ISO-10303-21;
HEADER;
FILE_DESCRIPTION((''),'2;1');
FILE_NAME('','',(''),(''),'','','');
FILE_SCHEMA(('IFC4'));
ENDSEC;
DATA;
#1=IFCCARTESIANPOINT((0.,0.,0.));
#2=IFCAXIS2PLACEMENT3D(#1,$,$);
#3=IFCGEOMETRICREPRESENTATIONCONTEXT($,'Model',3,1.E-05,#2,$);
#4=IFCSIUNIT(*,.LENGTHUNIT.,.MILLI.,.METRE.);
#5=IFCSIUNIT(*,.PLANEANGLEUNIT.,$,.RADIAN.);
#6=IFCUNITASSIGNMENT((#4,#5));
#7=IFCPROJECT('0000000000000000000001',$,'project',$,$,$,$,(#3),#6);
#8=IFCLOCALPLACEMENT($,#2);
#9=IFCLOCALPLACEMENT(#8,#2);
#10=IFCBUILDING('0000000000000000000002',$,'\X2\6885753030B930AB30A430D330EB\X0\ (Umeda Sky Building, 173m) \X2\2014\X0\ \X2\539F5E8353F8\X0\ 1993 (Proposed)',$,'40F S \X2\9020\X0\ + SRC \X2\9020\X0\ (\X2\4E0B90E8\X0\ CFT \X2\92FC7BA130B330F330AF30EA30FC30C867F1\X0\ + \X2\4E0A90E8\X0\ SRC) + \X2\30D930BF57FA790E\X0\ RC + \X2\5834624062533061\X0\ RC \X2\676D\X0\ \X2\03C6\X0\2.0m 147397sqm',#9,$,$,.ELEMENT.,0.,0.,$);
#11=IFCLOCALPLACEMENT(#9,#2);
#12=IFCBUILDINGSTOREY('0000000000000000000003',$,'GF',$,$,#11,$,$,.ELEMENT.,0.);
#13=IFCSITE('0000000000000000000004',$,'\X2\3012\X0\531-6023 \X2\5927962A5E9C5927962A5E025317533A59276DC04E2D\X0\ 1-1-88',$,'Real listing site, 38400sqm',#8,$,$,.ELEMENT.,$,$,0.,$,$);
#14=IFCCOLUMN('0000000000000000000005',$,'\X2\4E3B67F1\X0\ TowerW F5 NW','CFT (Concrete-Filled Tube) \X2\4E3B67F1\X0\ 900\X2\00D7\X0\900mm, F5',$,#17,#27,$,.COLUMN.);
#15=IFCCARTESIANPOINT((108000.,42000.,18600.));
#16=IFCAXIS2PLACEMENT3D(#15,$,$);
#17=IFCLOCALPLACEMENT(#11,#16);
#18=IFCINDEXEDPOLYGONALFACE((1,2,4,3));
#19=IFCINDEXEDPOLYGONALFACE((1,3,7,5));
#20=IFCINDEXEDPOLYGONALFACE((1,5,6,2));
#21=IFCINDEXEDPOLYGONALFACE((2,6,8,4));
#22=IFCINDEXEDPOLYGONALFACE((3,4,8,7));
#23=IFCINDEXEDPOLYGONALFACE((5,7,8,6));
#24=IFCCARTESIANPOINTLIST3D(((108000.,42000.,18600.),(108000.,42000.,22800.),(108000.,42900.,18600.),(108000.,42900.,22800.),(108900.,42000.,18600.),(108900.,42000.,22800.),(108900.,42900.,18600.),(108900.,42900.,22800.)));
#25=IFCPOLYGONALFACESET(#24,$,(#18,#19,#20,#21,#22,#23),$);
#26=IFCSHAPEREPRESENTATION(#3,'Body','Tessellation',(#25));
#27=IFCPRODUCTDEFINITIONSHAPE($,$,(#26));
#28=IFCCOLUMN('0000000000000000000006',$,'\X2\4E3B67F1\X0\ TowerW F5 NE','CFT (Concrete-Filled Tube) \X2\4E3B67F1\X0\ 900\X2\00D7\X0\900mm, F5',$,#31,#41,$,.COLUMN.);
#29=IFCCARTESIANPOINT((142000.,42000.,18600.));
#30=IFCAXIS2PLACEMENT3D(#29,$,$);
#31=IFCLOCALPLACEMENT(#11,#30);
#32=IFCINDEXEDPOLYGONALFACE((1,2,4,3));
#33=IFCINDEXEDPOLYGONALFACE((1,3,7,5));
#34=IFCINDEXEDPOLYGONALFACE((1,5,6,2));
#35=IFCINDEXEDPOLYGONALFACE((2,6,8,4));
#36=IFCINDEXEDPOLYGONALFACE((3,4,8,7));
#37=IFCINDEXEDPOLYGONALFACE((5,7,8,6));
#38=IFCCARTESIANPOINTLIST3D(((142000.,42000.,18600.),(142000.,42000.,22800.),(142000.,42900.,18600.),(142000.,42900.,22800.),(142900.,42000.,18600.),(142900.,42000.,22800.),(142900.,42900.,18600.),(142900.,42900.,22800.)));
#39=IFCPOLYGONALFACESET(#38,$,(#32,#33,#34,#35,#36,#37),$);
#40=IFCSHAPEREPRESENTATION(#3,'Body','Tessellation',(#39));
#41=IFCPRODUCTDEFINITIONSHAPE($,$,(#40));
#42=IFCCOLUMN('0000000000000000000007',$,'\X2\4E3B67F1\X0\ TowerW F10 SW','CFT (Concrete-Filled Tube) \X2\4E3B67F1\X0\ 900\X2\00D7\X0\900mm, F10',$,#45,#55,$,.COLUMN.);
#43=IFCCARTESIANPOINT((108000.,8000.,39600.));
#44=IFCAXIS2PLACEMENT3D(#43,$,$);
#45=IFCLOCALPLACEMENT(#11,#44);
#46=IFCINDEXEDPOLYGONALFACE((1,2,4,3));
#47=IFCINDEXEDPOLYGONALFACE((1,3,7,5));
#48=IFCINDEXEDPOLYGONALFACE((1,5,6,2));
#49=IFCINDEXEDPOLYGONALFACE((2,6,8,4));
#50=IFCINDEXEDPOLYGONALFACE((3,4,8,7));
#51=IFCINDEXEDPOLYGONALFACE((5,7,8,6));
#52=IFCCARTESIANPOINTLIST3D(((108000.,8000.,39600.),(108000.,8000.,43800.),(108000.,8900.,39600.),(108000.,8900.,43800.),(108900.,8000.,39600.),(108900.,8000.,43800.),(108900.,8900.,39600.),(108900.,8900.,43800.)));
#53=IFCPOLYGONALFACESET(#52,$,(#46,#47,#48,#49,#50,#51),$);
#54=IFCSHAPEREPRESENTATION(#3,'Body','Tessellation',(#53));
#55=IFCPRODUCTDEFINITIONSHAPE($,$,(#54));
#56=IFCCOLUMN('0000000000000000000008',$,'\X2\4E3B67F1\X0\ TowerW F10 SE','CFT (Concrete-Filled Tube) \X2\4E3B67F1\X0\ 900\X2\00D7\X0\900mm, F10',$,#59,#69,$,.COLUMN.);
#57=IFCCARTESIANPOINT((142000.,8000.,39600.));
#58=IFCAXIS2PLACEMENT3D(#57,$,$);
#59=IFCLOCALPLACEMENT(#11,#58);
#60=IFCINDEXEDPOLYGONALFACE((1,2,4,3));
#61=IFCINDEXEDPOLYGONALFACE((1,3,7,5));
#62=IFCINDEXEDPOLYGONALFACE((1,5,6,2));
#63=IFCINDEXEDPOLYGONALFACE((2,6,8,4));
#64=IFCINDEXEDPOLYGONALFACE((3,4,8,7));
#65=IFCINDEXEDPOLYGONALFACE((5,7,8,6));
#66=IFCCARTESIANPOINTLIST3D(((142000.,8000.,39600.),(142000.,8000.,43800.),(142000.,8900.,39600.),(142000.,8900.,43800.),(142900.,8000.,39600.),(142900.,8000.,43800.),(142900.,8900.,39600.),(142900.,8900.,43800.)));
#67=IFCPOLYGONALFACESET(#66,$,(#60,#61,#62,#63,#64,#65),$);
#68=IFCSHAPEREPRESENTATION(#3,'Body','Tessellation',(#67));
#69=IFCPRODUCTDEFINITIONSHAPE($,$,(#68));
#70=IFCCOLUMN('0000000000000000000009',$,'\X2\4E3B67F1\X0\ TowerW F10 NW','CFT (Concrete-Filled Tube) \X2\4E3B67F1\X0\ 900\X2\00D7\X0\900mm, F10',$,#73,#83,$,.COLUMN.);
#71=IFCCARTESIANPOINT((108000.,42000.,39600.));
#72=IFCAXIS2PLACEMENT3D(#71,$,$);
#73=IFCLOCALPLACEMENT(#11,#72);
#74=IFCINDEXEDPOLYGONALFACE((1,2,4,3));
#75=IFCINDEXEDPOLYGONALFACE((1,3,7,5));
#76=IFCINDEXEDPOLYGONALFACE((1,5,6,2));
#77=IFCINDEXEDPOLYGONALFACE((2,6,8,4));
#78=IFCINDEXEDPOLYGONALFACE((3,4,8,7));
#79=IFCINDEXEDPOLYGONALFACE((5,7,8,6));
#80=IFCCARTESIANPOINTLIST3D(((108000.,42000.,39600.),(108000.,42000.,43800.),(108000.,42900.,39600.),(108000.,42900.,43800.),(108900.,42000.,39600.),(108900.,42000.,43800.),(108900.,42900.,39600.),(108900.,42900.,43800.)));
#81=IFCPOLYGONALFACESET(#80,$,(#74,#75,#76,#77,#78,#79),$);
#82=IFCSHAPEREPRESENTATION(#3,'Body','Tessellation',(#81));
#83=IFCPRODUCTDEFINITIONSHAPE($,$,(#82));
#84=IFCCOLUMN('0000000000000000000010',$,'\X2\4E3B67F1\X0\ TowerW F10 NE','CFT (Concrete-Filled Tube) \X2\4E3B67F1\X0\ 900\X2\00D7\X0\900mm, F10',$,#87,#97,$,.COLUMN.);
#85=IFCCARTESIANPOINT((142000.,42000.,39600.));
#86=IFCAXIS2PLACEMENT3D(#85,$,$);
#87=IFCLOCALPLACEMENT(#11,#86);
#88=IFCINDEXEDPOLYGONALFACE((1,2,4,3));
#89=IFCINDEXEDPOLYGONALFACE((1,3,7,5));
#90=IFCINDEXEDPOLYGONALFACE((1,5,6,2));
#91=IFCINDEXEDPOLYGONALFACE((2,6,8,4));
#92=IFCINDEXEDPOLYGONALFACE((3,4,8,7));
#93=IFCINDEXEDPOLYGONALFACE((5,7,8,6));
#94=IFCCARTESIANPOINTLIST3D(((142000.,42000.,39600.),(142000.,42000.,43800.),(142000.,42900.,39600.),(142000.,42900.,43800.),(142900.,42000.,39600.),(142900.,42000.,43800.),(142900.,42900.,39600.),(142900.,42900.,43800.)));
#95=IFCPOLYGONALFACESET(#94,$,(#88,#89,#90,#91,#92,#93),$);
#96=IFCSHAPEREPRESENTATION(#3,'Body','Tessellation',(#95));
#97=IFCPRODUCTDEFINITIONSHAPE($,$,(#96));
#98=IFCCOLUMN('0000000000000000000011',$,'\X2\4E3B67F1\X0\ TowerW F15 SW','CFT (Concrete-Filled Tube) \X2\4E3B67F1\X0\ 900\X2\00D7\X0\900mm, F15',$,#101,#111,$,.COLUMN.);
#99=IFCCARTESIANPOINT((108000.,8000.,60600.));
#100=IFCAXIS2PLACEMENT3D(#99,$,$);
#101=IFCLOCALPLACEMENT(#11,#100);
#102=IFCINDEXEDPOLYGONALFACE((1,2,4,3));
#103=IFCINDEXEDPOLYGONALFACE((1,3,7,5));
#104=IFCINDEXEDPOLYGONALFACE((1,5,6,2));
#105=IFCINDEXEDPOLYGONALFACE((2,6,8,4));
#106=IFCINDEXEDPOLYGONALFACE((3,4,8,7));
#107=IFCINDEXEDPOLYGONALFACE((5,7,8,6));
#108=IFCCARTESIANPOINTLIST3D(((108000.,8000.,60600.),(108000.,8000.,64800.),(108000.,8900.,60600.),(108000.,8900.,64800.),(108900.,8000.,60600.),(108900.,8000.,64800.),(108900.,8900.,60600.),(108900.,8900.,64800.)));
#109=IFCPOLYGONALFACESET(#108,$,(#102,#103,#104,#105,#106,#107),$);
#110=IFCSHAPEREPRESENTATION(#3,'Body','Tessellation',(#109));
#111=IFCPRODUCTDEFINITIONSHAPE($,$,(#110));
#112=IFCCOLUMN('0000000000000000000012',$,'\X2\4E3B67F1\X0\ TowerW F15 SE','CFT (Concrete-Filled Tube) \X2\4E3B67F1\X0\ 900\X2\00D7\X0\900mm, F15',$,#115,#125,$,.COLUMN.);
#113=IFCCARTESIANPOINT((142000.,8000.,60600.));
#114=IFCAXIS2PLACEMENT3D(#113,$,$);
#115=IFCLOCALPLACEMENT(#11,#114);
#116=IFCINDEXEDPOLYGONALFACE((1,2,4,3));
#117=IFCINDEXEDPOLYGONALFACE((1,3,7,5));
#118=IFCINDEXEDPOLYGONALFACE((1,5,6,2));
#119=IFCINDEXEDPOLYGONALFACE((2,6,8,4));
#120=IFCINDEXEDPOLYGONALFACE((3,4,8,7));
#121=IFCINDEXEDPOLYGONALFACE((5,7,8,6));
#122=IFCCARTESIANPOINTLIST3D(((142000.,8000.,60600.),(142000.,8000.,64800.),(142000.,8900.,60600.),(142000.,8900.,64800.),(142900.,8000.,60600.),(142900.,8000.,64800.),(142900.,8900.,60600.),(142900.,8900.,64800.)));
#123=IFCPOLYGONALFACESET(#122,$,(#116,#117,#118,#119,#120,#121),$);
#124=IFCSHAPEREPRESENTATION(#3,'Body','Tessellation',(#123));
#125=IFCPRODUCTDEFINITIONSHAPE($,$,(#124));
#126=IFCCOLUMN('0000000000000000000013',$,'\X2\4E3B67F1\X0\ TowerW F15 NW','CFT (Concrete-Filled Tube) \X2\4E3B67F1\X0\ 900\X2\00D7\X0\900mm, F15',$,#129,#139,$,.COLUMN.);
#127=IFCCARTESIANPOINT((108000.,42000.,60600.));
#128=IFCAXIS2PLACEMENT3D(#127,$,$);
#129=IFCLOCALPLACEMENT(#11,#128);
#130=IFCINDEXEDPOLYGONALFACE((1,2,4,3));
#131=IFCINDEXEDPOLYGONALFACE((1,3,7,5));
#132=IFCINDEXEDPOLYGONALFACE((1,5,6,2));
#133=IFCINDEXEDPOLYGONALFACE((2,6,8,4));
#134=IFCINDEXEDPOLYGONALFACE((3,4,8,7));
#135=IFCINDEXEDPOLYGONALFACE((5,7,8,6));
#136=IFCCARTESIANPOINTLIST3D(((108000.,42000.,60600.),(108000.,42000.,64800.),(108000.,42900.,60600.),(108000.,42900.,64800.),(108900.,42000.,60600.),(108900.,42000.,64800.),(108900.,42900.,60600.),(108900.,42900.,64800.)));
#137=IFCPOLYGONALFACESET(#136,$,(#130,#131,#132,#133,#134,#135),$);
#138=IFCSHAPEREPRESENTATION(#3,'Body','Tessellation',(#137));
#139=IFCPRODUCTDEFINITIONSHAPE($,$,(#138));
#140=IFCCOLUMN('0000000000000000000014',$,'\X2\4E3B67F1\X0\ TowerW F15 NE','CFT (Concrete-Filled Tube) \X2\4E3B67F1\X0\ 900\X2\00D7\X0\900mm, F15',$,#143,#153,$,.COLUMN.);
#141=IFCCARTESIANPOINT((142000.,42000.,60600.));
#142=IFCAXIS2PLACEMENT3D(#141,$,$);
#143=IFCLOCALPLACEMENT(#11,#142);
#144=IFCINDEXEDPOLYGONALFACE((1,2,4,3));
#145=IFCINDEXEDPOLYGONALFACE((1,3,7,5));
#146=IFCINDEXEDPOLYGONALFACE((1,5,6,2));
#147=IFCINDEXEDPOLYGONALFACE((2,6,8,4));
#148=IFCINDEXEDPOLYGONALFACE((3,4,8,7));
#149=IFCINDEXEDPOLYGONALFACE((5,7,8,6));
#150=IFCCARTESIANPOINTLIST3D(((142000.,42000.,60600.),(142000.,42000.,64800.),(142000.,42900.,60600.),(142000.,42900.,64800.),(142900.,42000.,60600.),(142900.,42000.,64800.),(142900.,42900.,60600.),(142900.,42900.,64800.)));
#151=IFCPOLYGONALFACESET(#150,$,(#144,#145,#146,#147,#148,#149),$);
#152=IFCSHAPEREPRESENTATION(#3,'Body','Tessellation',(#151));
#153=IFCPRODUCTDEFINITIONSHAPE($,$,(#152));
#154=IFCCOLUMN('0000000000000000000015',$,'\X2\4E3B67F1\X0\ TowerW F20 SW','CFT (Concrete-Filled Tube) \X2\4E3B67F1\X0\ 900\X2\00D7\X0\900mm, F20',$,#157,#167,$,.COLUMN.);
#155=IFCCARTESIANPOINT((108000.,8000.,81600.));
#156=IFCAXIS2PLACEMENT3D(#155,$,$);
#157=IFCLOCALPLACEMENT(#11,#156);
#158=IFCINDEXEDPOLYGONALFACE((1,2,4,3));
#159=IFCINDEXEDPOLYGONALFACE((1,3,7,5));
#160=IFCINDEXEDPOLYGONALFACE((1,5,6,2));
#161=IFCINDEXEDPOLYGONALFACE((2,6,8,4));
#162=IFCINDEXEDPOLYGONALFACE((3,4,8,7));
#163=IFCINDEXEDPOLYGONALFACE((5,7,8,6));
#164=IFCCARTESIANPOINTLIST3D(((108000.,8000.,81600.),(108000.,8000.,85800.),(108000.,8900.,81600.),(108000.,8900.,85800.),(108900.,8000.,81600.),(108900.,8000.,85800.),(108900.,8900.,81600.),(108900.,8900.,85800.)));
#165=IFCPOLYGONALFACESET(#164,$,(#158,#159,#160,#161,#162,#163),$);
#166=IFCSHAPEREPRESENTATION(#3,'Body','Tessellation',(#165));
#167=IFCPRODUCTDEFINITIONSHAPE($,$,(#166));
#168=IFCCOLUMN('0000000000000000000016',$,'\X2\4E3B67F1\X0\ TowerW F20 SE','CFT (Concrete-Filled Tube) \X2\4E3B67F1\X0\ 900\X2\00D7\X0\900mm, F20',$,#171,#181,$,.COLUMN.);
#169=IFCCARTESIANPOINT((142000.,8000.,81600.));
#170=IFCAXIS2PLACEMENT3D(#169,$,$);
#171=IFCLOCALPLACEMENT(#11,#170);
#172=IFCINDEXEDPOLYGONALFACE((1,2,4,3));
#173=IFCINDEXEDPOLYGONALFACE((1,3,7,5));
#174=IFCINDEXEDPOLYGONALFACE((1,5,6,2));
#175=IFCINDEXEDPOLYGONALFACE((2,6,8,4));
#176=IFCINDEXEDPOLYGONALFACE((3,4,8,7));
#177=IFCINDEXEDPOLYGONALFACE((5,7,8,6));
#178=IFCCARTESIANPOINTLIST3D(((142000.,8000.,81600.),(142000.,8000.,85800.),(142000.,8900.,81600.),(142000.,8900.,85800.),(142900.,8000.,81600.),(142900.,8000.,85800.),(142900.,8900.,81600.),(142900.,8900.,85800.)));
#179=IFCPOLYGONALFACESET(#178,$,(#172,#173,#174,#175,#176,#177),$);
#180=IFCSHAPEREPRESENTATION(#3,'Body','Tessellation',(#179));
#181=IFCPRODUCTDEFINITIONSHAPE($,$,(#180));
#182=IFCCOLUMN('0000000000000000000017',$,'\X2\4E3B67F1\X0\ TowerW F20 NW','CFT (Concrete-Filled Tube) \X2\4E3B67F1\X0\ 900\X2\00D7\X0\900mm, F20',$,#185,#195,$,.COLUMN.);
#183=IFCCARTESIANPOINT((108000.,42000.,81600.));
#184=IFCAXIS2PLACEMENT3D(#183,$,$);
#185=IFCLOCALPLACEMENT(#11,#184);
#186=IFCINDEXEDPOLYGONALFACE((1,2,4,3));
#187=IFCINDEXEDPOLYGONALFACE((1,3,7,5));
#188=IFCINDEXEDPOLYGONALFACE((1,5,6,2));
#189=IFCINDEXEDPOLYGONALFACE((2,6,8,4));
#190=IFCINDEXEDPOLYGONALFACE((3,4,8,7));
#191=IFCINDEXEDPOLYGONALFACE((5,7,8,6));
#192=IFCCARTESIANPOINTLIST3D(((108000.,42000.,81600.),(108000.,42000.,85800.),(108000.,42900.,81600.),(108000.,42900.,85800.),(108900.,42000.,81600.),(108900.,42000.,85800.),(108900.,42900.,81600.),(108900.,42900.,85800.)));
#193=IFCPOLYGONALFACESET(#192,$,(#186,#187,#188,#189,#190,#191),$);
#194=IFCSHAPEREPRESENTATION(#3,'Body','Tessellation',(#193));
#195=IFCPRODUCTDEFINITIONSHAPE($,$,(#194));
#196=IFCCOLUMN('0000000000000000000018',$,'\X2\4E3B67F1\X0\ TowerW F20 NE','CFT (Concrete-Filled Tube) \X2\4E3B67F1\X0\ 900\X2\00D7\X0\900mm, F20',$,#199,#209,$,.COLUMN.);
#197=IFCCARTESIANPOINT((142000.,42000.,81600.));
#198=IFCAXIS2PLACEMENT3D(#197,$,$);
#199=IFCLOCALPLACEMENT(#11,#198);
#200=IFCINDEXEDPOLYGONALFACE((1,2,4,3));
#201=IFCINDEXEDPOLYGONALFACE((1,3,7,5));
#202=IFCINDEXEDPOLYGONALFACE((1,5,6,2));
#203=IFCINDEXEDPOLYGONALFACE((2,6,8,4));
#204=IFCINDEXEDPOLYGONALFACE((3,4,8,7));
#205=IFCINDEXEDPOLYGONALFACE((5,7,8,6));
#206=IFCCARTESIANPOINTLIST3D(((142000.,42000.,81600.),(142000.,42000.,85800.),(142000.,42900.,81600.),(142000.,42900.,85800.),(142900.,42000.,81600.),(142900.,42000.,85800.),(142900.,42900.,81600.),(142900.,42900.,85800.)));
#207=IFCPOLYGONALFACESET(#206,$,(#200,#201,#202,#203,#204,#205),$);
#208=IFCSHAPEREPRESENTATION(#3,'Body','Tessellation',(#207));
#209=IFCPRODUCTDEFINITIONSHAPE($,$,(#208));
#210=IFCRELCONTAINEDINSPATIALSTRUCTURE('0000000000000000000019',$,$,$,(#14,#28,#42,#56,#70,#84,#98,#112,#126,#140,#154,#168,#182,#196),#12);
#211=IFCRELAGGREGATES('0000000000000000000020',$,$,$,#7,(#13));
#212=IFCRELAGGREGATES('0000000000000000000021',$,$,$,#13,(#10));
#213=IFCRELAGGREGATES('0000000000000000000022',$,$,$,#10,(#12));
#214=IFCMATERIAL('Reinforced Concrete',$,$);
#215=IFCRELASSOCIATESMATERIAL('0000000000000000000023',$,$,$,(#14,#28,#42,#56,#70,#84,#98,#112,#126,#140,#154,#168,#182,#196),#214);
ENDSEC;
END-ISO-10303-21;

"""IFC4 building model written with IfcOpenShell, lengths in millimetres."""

from ifc_helpers import new_model, si_unit, frame, frame_2d, origin, place, context, project, spatial, rectangle, extrude, material, element, save


model = new_model("IFC4")

# Units and contexts
model_context = context("Model", 3, precision=1e-05, world=origin())
ifc_project = project(units=[si_unit("LENGTHUNIT", "METRE", prefix="MILLI"), si_unit("PLANEANGLEUNIT", "RADIAN")], contexts=[model_context])

# Site, building, storey
site_placement = place(None, origin())
site = spatial("IfcSite", under=ifc_project, at=site_placement, Name="〒531-6023 大阪府大阪市北区大淀中 1-1-88", ObjectType="Real listing site, 38400sqm", CompositionType="ELEMENT", RefElevation=0.0)
building_placement = place(site_placement, origin())
building = spatial("IfcBuilding", under=site, at=building_placement, Name="梅田スカイビル (Umeda Sky Building, 173m) — 原広司 1993 (Proposed)", ObjectType="40F S 造 + SRC 造 (下部 CFT 鋼管コンクリート柱 + 上部 SRC) + ベタ基礎 RC + 場所打ち RC 杭 φ2.0m 147397sqm", CompositionType="ELEMENT", ElevationOfRefHeight=0.0, ElevationOfTerrain=0.0)
storey_placement = place(building_placement, origin())
storey = spatial("IfcBuildingStorey", under=building, at=storey_placement, Name="GF", CompositionType="ELEMENT", Elevation=0.0)

# Shared definitions
ifc_material_1 = material(Name="Reinforced Concrete")

# Columns
column_1_placement = place(storey_placement, frame((108000.0, 42000.0, 18600.0)))
element("IfcColumn", 1, at=column_1_placement, inside=storey, material=ifc_material_1, Name="主柱 TowerW F5 NW", Description="CFT (Concrete-Filled Tube) 主柱 900×900mm, F5", PredefinedType="COLUMN", context=model_context, shape_type="SweptSolid", body=[
    extrude(rectangle(XDim=900.0, YDim=900.0, at=frame_2d((450.0, 450.0))), frame((108000.0, 42000.0, 18600.0)), (0.0, 0.0, 1.0), 4200.0),
])
column_2_placement = place(storey_placement, frame((142000.0, 42000.0, 18600.0)))
element("IfcColumn", 2, at=column_2_placement, inside=storey, material=ifc_material_1, Name="主柱 TowerW F5 NE", Description="CFT (Concrete-Filled Tube) 主柱 900×900mm, F5", PredefinedType="COLUMN", context=model_context, shape_type="SweptSolid", body=[
    extrude(rectangle(XDim=900.0, YDim=900.0, at=frame_2d((450.0, 450.0))), frame((142000.0, 42000.0, 18600.0)), (0.0, 0.0, 1.0), 4200.0),
])
column_3_placement = place(storey_placement, frame((108000.0, 8000.0, 39600.0)))
element("IfcColumn", 3, at=column_3_placement, inside=storey, material=ifc_material_1, Name="主柱 TowerW F10 SW", Description="CFT (Concrete-Filled Tube) 主柱 900×900mm, F10", PredefinedType="COLUMN", context=model_context, shape_type="SweptSolid", body=[
    extrude(rectangle(XDim=900.0, YDim=900.0, at=frame_2d((450.0, 450.0))), frame((108000.0, 8000.0, 39600.0)), (0.0, 0.0, 1.0), 4200.0),
])
column_4_placement = place(storey_placement, frame((142000.0, 8000.0, 39600.0)))
element("IfcColumn", 4, at=column_4_placement, inside=storey, material=ifc_material_1, Name="主柱 TowerW F10 SE", Description="CFT (Concrete-Filled Tube) 主柱 900×900mm, F10", PredefinedType="COLUMN", context=model_context, shape_type="SweptSolid", body=[
    extrude(rectangle(XDim=900.0, YDim=900.0, at=frame_2d((450.0, 450.0))), frame((142000.0, 8000.0, 39600.0)), (0.0, 0.0, 1.0), 4200.0),
])
column_5_placement = place(storey_placement, frame((108000.0, 42000.0, 39600.0)))
element("IfcColumn", 5, at=column_5_placement, inside=storey, material=ifc_material_1, Name="主柱 TowerW F10 NW", Description="CFT (Concrete-Filled Tube) 主柱 900×900mm, F10", PredefinedType="COLUMN", context=model_context, shape_type="SweptSolid", body=[
    extrude(rectangle(XDim=900.0, YDim=900.0, at=frame_2d((450.0, 450.0))), frame((108000.0, 42000.0, 39600.0)), (0.0, 0.0, 1.0), 4200.0),
])
column_6_placement = place(storey_placement, frame((142000.0, 42000.0, 39600.0)))
element("IfcColumn", 6, at=column_6_placement, inside=storey, material=ifc_material_1, Name="主柱 TowerW F10 NE", Description="CFT (Concrete-Filled Tube) 主柱 900×900mm, F10", PredefinedType="COLUMN", context=model_context, shape_type="SweptSolid", body=[
    extrude(rectangle(XDim=900.0, YDim=900.0, at=frame_2d((450.0, 450.0))), frame((142000.0, 42000.0, 39600.0)), (0.0, 0.0, 1.0), 4200.0),
])
column_7_placement = place(storey_placement, frame((108000.0, 8000.0, 60600.0)))
element("IfcColumn", 7, at=column_7_placement, inside=storey, material=ifc_material_1, Name="主柱 TowerW F15 SW", Description="CFT (Concrete-Filled Tube) 主柱 900×900mm, F15", PredefinedType="COLUMN", context=model_context, shape_type="SweptSolid", body=[
    extrude(rectangle(XDim=900.0, YDim=900.0, at=frame_2d((450.0, 450.0))), frame((108000.0, 8000.0, 60600.0)), (0.0, 0.0, 1.0), 4200.0),
])
column_8_placement = place(storey_placement, frame((142000.0, 8000.0, 60600.0)))
element("IfcColumn", 8, at=column_8_placement, inside=storey, material=ifc_material_1, Name="主柱 TowerW F15 SE", Description="CFT (Concrete-Filled Tube) 主柱 900×900mm, F15", PredefinedType="COLUMN", context=model_context, shape_type="SweptSolid", body=[
    extrude(rectangle(XDim=900.0, YDim=900.0, at=frame_2d((450.0, 450.0))), frame((142000.0, 8000.0, 60600.0)), (0.0, 0.0, 1.0), 4200.0),
])
column_9_placement = place(storey_placement, frame((108000.0, 42000.0, 60600.0)))
element("IfcColumn", 9, at=column_9_placement, inside=storey, material=ifc_material_1, Name="主柱 TowerW F15 NW", Description="CFT (Concrete-Filled Tube) 主柱 900×900mm, F15", PredefinedType="COLUMN", context=model_context, shape_type="SweptSolid", body=[
    extrude(rectangle(XDim=900.0, YDim=900.0, at=frame_2d((450.0, 450.0))), frame((108000.0, 42000.0, 60600.0)), (0.0, 0.0, 1.0), 4200.0),
])
column_10_placement = place(storey_placement, frame((142000.0, 42000.0, 60600.0)))
element("IfcColumn", 10, at=column_10_placement, inside=storey, material=ifc_material_1, Name="主柱 TowerW F15 NE", Description="CFT (Concrete-Filled Tube) 主柱 900×900mm, F15", PredefinedType="COLUMN", context=model_context, shape_type="SweptSolid", body=[
    extrude(rectangle(XDim=900.0, YDim=900.0, at=frame_2d((450.0, 450.0))), frame((142000.0, 42000.0, 60600.0)), (0.0, 0.0, 1.0), 4200.0),
])
column_11_placement = place(storey_placement, frame((108000.0, 8000.0, 81600.0)))
element("IfcColumn", 11, at=column_11_placement, inside=storey, material=ifc_material_1, Name="主柱 TowerW F20 SW", Description="CFT (Concrete-Filled Tube) 主柱 900×900mm, F20", PredefinedType="COLUMN", context=model_context, shape_type="SweptSolid", body=[
    extrude(rectangle(XDim=900.0, YDim=900.0, at=frame_2d((450.0, 450.0))), frame((108000.0, 8000.0, 81600.0)), (0.0, 0.0, 1.0), 4200.0),
])
column_12_placement = place(storey_placement, frame((142000.0, 8000.0, 81600.0)))
element("IfcColumn", 12, at=column_12_placement, inside=storey, material=ifc_material_1, Name="主柱 TowerW F20 SE", Description="CFT (Concrete-Filled Tube) 主柱 900×900mm, F20", PredefinedType="COLUMN", context=model_context, shape_type="SweptSolid", body=[
    extrude(rectangle(XDim=900.0, YDim=900.0, at=frame_2d((450.0, 450.0))), frame((142000.0, 8000.0, 81600.0)), (0.0, 0.0, 1.0), 4200.0),
])
column_13_placement = place(storey_placement, frame((108000.0, 42000.0, 81600.0)))
element("IfcColumn", 13, at=column_13_placement, inside=storey, material=ifc_material_1, Name="主柱 TowerW F20 NW", Description="CFT (Concrete-Filled Tube) 主柱 900×900mm, F20", PredefinedType="COLUMN", context=model_context, shape_type="SweptSolid", body=[
    extrude(rectangle(XDim=900.0, YDim=900.0, at=frame_2d((450.0, 450.0))), frame((108000.0, 42000.0, 81600.0)), (0.0, 0.0, 1.0), 4200.0),
])
column_14_placement = place(storey_placement, frame((142000.0, 42000.0, 81600.0)))
element("IfcColumn", 14, at=column_14_placement, inside=storey, material=ifc_material_1, Name="主柱 TowerW F20 NE", Description="CFT (Concrete-Filled Tube) 主柱 900×900mm, F20", PredefinedType="COLUMN", context=model_context, shape_type="SweptSolid", body=[
    extrude(rectangle(XDim=900.0, YDim=900.0, at=frame_2d((450.0, 450.0))), frame((142000.0, 42000.0, 81600.0)), (0.0, 0.0, 1.0), 4200.0),
])

save(model, "model.ifc")
